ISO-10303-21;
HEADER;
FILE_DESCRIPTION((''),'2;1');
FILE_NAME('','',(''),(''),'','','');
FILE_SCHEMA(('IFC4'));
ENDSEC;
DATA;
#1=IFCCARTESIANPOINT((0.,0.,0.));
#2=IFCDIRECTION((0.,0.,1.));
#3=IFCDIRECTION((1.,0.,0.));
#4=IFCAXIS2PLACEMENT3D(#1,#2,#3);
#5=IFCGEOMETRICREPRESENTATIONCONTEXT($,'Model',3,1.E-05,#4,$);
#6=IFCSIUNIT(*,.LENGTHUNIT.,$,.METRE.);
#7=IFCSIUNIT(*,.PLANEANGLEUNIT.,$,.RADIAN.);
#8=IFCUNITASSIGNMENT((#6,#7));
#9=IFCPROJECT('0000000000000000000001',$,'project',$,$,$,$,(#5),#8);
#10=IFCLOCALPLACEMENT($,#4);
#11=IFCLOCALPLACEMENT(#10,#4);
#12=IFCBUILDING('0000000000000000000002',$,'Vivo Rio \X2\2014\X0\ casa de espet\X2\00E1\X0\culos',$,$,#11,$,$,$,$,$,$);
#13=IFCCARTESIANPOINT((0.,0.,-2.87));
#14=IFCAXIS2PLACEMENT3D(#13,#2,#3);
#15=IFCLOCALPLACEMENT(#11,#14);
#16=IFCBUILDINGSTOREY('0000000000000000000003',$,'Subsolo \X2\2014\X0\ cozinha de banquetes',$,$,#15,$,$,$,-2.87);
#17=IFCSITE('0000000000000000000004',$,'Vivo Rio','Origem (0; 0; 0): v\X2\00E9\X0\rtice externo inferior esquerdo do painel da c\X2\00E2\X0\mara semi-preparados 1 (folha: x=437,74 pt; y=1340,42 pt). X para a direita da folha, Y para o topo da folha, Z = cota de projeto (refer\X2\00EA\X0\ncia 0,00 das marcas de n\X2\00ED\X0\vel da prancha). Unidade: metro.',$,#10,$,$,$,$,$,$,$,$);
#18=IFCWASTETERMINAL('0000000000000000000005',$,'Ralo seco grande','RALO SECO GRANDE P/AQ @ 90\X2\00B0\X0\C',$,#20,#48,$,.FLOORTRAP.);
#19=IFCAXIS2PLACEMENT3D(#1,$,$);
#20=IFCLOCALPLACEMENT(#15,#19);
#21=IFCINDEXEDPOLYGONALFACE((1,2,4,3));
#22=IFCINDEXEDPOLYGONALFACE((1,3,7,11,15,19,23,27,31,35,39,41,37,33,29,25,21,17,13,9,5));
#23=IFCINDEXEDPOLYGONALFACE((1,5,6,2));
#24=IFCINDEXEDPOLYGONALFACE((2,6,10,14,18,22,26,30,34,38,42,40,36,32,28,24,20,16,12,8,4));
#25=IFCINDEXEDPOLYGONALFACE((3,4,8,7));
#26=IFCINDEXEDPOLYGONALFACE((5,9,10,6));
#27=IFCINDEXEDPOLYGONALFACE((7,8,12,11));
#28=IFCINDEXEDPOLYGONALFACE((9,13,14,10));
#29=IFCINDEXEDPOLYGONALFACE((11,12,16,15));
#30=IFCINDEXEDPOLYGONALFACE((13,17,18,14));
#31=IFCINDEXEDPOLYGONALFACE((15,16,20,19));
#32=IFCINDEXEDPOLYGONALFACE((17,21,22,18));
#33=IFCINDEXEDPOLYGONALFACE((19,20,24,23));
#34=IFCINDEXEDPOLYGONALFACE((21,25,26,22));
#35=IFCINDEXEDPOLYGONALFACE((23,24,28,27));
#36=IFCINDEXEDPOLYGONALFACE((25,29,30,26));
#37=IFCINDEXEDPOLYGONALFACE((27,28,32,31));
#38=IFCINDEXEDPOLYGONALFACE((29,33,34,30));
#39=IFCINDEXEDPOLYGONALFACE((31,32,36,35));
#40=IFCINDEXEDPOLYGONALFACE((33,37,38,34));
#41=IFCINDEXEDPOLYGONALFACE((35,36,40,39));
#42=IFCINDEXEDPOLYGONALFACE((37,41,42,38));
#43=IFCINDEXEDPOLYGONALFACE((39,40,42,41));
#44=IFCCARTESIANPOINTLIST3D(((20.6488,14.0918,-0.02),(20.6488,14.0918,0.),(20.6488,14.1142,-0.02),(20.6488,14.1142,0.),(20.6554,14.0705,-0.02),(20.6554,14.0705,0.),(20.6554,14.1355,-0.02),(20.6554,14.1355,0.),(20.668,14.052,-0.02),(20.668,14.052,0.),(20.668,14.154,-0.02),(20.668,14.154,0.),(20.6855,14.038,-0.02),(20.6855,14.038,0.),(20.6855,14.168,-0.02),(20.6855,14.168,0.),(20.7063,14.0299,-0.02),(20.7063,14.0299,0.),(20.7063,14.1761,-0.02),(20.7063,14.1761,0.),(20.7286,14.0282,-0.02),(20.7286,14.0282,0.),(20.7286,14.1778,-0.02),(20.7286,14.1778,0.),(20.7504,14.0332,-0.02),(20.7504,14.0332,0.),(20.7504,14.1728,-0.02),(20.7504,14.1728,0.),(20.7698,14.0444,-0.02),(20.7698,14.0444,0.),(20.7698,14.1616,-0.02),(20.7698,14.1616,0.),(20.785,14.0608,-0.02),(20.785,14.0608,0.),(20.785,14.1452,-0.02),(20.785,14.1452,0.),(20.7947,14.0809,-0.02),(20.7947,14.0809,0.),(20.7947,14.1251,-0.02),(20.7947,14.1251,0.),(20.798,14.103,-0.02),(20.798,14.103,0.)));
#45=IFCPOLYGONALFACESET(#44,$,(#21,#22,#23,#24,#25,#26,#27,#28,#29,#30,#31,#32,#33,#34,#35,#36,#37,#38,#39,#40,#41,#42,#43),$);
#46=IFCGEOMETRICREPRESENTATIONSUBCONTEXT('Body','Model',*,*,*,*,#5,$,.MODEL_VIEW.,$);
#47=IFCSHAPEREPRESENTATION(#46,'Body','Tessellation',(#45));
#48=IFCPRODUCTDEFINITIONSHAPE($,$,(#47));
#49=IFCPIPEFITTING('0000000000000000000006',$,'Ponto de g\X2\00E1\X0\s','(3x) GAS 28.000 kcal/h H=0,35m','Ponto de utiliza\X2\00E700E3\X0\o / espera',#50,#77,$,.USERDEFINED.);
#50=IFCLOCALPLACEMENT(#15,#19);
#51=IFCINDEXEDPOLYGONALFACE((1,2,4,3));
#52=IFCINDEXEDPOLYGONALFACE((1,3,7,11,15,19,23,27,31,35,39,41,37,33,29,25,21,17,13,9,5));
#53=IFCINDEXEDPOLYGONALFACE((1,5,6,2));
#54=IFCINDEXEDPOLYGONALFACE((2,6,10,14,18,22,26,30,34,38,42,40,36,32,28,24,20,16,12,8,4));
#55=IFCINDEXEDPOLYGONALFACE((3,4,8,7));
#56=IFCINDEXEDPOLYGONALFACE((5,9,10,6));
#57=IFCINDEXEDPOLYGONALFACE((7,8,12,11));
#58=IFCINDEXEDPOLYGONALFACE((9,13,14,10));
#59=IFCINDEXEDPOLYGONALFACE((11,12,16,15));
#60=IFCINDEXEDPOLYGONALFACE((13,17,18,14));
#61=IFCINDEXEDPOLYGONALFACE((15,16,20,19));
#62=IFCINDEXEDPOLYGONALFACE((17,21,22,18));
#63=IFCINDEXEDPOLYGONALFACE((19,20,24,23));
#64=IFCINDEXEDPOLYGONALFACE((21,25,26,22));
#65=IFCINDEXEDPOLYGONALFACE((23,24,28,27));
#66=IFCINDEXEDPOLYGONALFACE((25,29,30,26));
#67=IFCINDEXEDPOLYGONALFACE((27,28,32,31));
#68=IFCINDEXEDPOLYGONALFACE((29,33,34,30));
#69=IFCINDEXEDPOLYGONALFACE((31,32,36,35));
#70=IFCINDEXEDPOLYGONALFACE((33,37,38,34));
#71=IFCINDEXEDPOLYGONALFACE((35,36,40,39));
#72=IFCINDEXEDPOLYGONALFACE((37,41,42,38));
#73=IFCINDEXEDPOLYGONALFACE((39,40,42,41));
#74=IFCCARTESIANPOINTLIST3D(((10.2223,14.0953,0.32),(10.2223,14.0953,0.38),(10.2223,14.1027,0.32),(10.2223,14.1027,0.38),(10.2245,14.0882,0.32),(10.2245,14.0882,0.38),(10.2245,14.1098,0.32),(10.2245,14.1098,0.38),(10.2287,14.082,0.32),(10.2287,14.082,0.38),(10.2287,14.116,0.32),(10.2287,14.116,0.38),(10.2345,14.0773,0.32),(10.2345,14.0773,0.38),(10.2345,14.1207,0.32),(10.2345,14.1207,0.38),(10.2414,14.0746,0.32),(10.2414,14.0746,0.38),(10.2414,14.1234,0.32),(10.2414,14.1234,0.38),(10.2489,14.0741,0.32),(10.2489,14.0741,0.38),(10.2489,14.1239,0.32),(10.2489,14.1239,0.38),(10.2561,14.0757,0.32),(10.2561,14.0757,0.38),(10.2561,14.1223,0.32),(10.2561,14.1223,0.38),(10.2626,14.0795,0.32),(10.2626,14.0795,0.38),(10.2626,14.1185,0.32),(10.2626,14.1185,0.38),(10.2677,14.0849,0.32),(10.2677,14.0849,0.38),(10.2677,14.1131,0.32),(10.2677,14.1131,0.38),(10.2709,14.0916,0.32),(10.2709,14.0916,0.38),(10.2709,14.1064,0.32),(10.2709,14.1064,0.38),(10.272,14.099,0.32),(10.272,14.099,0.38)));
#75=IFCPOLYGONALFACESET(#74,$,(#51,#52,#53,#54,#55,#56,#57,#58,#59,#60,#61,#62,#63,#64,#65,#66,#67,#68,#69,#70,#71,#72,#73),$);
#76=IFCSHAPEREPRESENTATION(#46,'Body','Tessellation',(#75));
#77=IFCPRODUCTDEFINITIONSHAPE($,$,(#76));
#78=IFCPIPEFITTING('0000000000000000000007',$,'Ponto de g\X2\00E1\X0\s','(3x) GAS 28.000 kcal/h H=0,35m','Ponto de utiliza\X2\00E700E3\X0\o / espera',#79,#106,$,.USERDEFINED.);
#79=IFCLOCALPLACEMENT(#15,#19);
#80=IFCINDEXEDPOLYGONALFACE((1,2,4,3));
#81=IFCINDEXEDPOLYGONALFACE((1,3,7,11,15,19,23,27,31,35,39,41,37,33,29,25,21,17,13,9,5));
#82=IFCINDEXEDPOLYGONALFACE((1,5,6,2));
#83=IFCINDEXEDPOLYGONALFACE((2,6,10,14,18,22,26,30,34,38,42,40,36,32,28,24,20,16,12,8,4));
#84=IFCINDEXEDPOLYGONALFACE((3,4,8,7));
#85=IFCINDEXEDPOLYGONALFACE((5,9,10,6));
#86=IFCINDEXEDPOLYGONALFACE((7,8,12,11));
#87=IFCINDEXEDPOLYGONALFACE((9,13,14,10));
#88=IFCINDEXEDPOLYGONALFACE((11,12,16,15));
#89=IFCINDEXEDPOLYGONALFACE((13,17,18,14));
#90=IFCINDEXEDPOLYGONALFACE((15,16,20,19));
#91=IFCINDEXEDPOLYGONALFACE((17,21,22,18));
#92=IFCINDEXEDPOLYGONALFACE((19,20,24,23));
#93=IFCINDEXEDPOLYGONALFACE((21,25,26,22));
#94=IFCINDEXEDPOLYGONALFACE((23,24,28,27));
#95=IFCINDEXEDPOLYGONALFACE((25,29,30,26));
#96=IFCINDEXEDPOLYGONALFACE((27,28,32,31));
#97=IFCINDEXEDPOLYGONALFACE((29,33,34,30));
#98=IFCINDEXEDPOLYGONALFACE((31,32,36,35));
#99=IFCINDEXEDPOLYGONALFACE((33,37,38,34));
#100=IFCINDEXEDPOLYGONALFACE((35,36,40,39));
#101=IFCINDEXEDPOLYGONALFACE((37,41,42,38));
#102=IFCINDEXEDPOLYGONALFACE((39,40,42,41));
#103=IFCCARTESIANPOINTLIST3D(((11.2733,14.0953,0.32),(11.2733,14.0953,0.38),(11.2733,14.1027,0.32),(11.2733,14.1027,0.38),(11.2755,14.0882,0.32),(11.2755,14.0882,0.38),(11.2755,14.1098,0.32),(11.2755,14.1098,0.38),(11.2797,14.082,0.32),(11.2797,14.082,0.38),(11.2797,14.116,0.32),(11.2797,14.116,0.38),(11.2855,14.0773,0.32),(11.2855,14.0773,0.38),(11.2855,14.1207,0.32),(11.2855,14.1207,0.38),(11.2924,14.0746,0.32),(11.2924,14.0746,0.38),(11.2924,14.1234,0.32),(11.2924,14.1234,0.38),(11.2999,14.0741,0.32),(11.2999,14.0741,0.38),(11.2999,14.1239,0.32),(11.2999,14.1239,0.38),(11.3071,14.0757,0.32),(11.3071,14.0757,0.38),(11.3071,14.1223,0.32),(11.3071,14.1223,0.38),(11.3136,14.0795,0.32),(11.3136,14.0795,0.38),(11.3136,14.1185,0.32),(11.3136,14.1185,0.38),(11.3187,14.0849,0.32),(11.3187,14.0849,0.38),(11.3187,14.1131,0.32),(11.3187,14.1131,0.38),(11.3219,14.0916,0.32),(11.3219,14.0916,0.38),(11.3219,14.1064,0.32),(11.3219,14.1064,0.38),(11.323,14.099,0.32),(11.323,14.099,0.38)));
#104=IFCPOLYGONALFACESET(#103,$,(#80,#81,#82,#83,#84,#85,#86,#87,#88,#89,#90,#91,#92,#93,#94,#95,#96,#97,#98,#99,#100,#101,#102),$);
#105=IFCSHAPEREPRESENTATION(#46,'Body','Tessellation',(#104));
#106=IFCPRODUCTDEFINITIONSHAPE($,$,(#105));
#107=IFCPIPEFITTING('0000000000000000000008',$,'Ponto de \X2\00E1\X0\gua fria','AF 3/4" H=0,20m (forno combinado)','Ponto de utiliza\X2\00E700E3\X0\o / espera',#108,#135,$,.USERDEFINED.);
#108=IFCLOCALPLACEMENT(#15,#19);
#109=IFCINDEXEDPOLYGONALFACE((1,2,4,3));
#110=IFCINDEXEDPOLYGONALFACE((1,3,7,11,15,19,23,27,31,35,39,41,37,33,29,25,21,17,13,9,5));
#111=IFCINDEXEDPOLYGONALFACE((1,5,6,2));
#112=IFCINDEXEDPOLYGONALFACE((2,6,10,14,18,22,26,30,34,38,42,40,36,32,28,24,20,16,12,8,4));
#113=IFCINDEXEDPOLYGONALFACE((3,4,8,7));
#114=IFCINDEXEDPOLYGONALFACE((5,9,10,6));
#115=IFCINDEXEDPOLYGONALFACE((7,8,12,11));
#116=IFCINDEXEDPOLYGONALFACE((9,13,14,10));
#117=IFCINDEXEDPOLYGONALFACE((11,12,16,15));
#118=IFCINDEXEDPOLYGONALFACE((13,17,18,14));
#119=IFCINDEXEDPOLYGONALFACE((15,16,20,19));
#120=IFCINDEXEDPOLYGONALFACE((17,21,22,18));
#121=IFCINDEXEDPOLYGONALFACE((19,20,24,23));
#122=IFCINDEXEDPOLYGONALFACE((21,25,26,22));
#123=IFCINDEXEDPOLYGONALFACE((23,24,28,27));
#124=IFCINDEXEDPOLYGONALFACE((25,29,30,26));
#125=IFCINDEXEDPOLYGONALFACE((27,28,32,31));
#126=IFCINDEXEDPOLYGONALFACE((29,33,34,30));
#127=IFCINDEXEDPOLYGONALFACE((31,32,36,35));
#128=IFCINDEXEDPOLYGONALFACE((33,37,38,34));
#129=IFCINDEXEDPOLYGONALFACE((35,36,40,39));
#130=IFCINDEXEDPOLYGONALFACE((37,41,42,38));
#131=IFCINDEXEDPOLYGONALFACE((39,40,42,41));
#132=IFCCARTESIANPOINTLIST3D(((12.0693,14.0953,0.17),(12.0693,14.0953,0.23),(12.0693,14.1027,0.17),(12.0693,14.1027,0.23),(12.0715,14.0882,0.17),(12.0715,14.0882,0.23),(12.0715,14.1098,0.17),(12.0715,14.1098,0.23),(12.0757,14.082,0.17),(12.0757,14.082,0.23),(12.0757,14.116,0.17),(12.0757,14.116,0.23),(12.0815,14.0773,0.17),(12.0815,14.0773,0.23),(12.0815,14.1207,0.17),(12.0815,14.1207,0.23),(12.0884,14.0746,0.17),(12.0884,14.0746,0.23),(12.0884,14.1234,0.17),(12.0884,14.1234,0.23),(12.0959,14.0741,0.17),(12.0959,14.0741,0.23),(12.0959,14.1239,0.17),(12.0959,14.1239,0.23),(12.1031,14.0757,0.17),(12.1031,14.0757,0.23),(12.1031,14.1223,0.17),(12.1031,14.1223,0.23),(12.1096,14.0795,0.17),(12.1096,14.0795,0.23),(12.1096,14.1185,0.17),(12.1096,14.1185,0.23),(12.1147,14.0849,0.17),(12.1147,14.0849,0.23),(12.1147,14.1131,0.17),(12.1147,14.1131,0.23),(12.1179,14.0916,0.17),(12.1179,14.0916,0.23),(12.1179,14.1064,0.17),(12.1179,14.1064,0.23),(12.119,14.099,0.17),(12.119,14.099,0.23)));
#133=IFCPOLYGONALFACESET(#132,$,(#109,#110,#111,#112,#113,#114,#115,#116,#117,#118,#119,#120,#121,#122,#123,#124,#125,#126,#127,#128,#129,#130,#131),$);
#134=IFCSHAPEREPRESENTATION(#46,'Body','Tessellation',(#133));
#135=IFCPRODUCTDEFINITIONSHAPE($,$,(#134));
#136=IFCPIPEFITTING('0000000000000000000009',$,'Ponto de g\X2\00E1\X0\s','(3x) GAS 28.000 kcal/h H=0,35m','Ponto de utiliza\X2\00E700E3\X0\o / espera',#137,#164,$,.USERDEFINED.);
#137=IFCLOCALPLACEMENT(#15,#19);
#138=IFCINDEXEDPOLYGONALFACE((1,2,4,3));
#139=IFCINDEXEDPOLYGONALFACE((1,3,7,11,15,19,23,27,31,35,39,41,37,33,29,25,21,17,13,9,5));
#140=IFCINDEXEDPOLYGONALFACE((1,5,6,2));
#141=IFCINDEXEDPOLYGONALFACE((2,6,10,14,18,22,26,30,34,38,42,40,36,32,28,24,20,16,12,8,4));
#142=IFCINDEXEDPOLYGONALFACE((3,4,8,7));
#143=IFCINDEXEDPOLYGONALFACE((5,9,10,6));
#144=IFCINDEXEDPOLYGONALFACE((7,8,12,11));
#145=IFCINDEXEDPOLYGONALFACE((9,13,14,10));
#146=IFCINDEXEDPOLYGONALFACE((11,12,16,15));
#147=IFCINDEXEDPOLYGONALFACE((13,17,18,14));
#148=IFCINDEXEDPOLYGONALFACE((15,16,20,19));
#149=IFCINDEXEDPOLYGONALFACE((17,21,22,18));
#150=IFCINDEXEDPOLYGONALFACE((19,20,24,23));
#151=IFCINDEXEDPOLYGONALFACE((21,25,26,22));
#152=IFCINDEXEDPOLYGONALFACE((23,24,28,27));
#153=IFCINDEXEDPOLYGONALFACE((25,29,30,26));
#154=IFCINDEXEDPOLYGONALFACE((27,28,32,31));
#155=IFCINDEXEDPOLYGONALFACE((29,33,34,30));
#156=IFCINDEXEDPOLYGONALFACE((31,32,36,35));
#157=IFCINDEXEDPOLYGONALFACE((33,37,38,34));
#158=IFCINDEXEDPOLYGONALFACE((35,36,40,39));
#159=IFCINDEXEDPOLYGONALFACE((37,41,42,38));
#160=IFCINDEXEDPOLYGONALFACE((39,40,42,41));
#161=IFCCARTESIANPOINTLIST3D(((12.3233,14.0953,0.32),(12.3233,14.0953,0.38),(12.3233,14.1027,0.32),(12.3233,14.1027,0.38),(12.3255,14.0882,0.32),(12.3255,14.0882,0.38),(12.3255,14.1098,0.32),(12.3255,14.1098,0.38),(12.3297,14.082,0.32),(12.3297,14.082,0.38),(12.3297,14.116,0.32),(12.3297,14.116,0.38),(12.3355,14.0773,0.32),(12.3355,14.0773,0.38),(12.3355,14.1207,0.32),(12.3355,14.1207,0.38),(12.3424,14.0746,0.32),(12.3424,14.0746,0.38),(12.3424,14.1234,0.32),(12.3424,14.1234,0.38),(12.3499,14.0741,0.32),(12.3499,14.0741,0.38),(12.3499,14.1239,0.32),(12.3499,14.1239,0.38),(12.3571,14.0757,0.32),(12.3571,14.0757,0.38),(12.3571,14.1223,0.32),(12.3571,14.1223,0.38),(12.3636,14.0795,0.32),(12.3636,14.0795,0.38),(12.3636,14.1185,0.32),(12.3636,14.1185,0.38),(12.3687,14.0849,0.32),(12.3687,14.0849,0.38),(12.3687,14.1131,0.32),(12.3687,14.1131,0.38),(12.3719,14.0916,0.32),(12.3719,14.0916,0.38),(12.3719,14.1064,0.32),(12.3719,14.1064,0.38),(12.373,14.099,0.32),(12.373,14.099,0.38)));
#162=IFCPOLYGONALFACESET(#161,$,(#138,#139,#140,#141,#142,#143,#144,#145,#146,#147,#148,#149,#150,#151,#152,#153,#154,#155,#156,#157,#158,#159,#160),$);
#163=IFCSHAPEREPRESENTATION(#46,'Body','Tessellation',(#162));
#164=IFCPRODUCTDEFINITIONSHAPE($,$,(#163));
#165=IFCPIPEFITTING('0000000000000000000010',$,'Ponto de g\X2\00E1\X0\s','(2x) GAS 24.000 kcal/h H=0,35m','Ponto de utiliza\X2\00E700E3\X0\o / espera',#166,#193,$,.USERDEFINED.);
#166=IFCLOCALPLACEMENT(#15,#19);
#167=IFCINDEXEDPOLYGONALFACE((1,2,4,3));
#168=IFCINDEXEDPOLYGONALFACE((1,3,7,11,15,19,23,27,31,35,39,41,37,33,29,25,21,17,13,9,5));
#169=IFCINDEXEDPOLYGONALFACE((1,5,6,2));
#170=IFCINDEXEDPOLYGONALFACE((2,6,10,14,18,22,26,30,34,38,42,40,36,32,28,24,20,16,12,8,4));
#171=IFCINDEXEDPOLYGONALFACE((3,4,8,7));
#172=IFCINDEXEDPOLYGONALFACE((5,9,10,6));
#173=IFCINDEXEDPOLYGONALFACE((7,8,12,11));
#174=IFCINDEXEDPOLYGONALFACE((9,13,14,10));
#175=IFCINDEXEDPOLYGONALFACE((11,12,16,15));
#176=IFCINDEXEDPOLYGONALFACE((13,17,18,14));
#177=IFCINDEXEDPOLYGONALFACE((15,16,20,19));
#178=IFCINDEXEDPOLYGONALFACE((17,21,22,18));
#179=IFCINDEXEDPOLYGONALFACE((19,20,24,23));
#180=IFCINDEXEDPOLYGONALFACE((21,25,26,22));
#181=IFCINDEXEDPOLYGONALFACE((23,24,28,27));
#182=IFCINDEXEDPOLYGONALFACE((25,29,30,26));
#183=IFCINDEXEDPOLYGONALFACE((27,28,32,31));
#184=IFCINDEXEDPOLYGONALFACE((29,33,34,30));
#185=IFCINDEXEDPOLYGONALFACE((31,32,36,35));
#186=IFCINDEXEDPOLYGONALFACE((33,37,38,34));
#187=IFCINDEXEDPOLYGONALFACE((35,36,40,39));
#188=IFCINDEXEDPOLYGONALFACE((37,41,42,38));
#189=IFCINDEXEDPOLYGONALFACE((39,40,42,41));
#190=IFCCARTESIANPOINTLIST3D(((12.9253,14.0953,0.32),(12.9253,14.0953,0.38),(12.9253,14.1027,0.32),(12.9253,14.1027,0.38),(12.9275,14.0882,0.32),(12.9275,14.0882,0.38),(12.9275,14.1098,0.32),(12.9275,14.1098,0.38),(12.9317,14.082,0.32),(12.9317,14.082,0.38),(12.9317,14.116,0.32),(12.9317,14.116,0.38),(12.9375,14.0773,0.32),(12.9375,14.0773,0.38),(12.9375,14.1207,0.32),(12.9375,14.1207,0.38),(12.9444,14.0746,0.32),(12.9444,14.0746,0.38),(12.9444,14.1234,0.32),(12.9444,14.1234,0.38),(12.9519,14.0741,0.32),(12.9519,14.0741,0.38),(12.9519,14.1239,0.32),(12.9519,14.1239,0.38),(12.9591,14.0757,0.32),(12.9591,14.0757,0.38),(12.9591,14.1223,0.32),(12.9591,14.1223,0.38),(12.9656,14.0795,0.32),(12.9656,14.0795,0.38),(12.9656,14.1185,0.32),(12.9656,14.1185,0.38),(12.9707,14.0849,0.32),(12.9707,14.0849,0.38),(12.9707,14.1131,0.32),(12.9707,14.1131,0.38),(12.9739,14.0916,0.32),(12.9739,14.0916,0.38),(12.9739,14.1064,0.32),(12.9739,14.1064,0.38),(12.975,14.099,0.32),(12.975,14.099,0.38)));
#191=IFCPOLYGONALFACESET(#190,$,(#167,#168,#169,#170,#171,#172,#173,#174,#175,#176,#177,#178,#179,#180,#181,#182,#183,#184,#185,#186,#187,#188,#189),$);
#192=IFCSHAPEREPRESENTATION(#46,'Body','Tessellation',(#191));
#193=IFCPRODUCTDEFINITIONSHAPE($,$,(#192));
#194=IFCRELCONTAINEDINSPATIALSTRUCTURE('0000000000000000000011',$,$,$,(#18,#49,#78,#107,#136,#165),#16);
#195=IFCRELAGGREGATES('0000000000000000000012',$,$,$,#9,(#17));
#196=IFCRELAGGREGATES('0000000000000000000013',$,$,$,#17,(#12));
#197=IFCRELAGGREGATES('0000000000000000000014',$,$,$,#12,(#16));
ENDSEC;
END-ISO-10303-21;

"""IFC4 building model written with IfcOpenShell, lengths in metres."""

from ifc_helpers import new_model, si_unit, frame, origin_with_axes, origin_2d, place, context, subcontext, project, spatial, circle, extrude, element, save


model = new_model("IFC4")

# Units and contexts
model_context = context("Model", 3, precision=1e-05, world=origin_with_axes())
body_context = subcontext(model_context, "Body", "Model", "MODEL_VIEW")
ifc_project = project(units=[si_unit("LENGTHUNIT", "METRE"), si_unit("PLANEANGLEUNIT", "RADIAN")], contexts=[model_context])

# Site, building, storey
site_placement = place(None, origin_with_axes())
site = spatial("IfcSite", under=ifc_project, at=site_placement, Name="Vivo Rio", Description="Origem (0; 0; 0): vértice externo inferior esquerdo do painel da câmara semi-preparados 1 (folha: x=437,74 pt; y=1340,42 pt). X para a direita da folha, Y para o topo da folha, Z = cota de projeto (referência 0,00 das marcas de nível da prancha). Unidade: metro.")
building_placement = place(site_placement, origin_with_axes())
building = spatial("IfcBuilding", under=site, at=building_placement, Name="Vivo Rio — casa de espetáculos")
storey_placement = place(building_placement, frame((0.0, 0.0, -2.87), z_axis=(0.0, 0.0, 1.0), x_axis=(1.0, 0.0, 0.0)))
storey = spatial("IfcBuildingStorey", under=building, at=storey_placement, Name="Subsolo — cozinha de banquetes", Elevation=-2.87)

# Waste terminal
waste_terminal_1_placement = place(storey_placement, origin_with_axes())
element("IfcWasteTerminal", 1, at=waste_terminal_1_placement, inside=storey, Name="Ralo seco grande", Description="RALO SECO GRANDE P/AQ @ 90°C", PredefinedType="FLOORTRAP", context=body_context, shape_type="SweptSolid", body=[
    extrude(circle(Radius=0.075, at=origin_2d()), frame((20.723, 14.103, -0.02), z_axis=(0.0, 0.0, 1.0), x_axis=(1.0, 0.0, 0.0)), (0.0, 0.0, 1.0), 0.02),
])

# Pipe fittings
pipe_fitting_1_placement = place(storey_placement, origin_with_axes())
element("IfcPipeFitting", 2, at=pipe_fitting_1_placement, inside=storey, Name="Ponto de gás", Description="(3x) GAS 28.000 kcal/h H=0,35m", ObjectType="Ponto de utilização / espera", PredefinedType="USERDEFINED", context=body_context, shape_type="SweptSolid", body=[
    extrude(circle(Radius=0.025, at=origin_2d()), frame((10.247, 14.099, 0.32), z_axis=(0.0, 0.0, 1.0), x_axis=(1.0, 0.0, 0.0)), (0.0, 0.0, 1.0), 0.06),
])
pipe_fitting_2_placement = place(storey_placement, origin_with_axes())
element("IfcPipeFitting", 3, at=pipe_fitting_2_placement, inside=storey, Name="Ponto de gás", Description="(3x) GAS 28.000 kcal/h H=0,35m", ObjectType="Ponto de utilização / espera", PredefinedType="USERDEFINED", context=body_context, shape_type="SweptSolid", body=[
    extrude(circle(Radius=0.025, at=origin_2d()), frame((11.298, 14.099, 0.32), z_axis=(0.0, 0.0, 1.0), x_axis=(1.0, 0.0, 0.0)), (0.0, 0.0, 1.0), 0.06),
])
pipe_fitting_3_placement = place(storey_placement, origin_with_axes())
element("IfcPipeFitting", 4, at=pipe_fitting_3_placement, inside=storey, Name="Ponto de água fria", Description="AF 3/4\" H=0,20m (forno combinado)", ObjectType="Ponto de utilização / espera", PredefinedType="USERDEFINED", context=body_context, shape_type="SweptSolid", body=[
    extrude(circle(Radius=0.025, at=origin_2d()), frame((12.094, 14.099, 0.17), z_axis=(0.0, 0.0, 1.0), x_axis=(1.0, 0.0, 0.0)), (0.0, 0.0, 1.0), 0.06),
])
pipe_fitting_4_placement = place(storey_placement, origin_with_axes())
element("IfcPipeFitting", 5, at=pipe_fitting_4_placement, inside=storey, Name="Ponto de gás", Description="(3x) GAS 28.000 kcal/h H=0,35m", ObjectType="Ponto de utilização / espera", PredefinedType="USERDEFINED", context=body_context, shape_type="SweptSolid", body=[
    extrude(circle(Radius=0.025, at=origin_2d()), frame((12.348, 14.099, 0.32), z_axis=(0.0, 0.0, 1.0), x_axis=(1.0, 0.0, 0.0)), (0.0, 0.0, 1.0), 0.06),
])
pipe_fitting_5_placement = place(storey_placement, origin_with_axes())
element("IfcPipeFitting", 6, at=pipe_fitting_5_placement, inside=storey, Name="Ponto de gás", Description="(2x) GAS 24.000 kcal/h H=0,35m", ObjectType="Ponto de utilização / espera", PredefinedType="USERDEFINED", context=body_context, shape_type="SweptSolid", body=[
    extrude(circle(Radius=0.025, at=origin_2d()), frame((12.95, 14.099, 0.32), z_axis=(0.0, 0.0, 1.0), x_axis=(1.0, 0.0, 0.0)), (0.0, 0.0, 1.0), 0.06),
])

save(model, "model.ifc")
